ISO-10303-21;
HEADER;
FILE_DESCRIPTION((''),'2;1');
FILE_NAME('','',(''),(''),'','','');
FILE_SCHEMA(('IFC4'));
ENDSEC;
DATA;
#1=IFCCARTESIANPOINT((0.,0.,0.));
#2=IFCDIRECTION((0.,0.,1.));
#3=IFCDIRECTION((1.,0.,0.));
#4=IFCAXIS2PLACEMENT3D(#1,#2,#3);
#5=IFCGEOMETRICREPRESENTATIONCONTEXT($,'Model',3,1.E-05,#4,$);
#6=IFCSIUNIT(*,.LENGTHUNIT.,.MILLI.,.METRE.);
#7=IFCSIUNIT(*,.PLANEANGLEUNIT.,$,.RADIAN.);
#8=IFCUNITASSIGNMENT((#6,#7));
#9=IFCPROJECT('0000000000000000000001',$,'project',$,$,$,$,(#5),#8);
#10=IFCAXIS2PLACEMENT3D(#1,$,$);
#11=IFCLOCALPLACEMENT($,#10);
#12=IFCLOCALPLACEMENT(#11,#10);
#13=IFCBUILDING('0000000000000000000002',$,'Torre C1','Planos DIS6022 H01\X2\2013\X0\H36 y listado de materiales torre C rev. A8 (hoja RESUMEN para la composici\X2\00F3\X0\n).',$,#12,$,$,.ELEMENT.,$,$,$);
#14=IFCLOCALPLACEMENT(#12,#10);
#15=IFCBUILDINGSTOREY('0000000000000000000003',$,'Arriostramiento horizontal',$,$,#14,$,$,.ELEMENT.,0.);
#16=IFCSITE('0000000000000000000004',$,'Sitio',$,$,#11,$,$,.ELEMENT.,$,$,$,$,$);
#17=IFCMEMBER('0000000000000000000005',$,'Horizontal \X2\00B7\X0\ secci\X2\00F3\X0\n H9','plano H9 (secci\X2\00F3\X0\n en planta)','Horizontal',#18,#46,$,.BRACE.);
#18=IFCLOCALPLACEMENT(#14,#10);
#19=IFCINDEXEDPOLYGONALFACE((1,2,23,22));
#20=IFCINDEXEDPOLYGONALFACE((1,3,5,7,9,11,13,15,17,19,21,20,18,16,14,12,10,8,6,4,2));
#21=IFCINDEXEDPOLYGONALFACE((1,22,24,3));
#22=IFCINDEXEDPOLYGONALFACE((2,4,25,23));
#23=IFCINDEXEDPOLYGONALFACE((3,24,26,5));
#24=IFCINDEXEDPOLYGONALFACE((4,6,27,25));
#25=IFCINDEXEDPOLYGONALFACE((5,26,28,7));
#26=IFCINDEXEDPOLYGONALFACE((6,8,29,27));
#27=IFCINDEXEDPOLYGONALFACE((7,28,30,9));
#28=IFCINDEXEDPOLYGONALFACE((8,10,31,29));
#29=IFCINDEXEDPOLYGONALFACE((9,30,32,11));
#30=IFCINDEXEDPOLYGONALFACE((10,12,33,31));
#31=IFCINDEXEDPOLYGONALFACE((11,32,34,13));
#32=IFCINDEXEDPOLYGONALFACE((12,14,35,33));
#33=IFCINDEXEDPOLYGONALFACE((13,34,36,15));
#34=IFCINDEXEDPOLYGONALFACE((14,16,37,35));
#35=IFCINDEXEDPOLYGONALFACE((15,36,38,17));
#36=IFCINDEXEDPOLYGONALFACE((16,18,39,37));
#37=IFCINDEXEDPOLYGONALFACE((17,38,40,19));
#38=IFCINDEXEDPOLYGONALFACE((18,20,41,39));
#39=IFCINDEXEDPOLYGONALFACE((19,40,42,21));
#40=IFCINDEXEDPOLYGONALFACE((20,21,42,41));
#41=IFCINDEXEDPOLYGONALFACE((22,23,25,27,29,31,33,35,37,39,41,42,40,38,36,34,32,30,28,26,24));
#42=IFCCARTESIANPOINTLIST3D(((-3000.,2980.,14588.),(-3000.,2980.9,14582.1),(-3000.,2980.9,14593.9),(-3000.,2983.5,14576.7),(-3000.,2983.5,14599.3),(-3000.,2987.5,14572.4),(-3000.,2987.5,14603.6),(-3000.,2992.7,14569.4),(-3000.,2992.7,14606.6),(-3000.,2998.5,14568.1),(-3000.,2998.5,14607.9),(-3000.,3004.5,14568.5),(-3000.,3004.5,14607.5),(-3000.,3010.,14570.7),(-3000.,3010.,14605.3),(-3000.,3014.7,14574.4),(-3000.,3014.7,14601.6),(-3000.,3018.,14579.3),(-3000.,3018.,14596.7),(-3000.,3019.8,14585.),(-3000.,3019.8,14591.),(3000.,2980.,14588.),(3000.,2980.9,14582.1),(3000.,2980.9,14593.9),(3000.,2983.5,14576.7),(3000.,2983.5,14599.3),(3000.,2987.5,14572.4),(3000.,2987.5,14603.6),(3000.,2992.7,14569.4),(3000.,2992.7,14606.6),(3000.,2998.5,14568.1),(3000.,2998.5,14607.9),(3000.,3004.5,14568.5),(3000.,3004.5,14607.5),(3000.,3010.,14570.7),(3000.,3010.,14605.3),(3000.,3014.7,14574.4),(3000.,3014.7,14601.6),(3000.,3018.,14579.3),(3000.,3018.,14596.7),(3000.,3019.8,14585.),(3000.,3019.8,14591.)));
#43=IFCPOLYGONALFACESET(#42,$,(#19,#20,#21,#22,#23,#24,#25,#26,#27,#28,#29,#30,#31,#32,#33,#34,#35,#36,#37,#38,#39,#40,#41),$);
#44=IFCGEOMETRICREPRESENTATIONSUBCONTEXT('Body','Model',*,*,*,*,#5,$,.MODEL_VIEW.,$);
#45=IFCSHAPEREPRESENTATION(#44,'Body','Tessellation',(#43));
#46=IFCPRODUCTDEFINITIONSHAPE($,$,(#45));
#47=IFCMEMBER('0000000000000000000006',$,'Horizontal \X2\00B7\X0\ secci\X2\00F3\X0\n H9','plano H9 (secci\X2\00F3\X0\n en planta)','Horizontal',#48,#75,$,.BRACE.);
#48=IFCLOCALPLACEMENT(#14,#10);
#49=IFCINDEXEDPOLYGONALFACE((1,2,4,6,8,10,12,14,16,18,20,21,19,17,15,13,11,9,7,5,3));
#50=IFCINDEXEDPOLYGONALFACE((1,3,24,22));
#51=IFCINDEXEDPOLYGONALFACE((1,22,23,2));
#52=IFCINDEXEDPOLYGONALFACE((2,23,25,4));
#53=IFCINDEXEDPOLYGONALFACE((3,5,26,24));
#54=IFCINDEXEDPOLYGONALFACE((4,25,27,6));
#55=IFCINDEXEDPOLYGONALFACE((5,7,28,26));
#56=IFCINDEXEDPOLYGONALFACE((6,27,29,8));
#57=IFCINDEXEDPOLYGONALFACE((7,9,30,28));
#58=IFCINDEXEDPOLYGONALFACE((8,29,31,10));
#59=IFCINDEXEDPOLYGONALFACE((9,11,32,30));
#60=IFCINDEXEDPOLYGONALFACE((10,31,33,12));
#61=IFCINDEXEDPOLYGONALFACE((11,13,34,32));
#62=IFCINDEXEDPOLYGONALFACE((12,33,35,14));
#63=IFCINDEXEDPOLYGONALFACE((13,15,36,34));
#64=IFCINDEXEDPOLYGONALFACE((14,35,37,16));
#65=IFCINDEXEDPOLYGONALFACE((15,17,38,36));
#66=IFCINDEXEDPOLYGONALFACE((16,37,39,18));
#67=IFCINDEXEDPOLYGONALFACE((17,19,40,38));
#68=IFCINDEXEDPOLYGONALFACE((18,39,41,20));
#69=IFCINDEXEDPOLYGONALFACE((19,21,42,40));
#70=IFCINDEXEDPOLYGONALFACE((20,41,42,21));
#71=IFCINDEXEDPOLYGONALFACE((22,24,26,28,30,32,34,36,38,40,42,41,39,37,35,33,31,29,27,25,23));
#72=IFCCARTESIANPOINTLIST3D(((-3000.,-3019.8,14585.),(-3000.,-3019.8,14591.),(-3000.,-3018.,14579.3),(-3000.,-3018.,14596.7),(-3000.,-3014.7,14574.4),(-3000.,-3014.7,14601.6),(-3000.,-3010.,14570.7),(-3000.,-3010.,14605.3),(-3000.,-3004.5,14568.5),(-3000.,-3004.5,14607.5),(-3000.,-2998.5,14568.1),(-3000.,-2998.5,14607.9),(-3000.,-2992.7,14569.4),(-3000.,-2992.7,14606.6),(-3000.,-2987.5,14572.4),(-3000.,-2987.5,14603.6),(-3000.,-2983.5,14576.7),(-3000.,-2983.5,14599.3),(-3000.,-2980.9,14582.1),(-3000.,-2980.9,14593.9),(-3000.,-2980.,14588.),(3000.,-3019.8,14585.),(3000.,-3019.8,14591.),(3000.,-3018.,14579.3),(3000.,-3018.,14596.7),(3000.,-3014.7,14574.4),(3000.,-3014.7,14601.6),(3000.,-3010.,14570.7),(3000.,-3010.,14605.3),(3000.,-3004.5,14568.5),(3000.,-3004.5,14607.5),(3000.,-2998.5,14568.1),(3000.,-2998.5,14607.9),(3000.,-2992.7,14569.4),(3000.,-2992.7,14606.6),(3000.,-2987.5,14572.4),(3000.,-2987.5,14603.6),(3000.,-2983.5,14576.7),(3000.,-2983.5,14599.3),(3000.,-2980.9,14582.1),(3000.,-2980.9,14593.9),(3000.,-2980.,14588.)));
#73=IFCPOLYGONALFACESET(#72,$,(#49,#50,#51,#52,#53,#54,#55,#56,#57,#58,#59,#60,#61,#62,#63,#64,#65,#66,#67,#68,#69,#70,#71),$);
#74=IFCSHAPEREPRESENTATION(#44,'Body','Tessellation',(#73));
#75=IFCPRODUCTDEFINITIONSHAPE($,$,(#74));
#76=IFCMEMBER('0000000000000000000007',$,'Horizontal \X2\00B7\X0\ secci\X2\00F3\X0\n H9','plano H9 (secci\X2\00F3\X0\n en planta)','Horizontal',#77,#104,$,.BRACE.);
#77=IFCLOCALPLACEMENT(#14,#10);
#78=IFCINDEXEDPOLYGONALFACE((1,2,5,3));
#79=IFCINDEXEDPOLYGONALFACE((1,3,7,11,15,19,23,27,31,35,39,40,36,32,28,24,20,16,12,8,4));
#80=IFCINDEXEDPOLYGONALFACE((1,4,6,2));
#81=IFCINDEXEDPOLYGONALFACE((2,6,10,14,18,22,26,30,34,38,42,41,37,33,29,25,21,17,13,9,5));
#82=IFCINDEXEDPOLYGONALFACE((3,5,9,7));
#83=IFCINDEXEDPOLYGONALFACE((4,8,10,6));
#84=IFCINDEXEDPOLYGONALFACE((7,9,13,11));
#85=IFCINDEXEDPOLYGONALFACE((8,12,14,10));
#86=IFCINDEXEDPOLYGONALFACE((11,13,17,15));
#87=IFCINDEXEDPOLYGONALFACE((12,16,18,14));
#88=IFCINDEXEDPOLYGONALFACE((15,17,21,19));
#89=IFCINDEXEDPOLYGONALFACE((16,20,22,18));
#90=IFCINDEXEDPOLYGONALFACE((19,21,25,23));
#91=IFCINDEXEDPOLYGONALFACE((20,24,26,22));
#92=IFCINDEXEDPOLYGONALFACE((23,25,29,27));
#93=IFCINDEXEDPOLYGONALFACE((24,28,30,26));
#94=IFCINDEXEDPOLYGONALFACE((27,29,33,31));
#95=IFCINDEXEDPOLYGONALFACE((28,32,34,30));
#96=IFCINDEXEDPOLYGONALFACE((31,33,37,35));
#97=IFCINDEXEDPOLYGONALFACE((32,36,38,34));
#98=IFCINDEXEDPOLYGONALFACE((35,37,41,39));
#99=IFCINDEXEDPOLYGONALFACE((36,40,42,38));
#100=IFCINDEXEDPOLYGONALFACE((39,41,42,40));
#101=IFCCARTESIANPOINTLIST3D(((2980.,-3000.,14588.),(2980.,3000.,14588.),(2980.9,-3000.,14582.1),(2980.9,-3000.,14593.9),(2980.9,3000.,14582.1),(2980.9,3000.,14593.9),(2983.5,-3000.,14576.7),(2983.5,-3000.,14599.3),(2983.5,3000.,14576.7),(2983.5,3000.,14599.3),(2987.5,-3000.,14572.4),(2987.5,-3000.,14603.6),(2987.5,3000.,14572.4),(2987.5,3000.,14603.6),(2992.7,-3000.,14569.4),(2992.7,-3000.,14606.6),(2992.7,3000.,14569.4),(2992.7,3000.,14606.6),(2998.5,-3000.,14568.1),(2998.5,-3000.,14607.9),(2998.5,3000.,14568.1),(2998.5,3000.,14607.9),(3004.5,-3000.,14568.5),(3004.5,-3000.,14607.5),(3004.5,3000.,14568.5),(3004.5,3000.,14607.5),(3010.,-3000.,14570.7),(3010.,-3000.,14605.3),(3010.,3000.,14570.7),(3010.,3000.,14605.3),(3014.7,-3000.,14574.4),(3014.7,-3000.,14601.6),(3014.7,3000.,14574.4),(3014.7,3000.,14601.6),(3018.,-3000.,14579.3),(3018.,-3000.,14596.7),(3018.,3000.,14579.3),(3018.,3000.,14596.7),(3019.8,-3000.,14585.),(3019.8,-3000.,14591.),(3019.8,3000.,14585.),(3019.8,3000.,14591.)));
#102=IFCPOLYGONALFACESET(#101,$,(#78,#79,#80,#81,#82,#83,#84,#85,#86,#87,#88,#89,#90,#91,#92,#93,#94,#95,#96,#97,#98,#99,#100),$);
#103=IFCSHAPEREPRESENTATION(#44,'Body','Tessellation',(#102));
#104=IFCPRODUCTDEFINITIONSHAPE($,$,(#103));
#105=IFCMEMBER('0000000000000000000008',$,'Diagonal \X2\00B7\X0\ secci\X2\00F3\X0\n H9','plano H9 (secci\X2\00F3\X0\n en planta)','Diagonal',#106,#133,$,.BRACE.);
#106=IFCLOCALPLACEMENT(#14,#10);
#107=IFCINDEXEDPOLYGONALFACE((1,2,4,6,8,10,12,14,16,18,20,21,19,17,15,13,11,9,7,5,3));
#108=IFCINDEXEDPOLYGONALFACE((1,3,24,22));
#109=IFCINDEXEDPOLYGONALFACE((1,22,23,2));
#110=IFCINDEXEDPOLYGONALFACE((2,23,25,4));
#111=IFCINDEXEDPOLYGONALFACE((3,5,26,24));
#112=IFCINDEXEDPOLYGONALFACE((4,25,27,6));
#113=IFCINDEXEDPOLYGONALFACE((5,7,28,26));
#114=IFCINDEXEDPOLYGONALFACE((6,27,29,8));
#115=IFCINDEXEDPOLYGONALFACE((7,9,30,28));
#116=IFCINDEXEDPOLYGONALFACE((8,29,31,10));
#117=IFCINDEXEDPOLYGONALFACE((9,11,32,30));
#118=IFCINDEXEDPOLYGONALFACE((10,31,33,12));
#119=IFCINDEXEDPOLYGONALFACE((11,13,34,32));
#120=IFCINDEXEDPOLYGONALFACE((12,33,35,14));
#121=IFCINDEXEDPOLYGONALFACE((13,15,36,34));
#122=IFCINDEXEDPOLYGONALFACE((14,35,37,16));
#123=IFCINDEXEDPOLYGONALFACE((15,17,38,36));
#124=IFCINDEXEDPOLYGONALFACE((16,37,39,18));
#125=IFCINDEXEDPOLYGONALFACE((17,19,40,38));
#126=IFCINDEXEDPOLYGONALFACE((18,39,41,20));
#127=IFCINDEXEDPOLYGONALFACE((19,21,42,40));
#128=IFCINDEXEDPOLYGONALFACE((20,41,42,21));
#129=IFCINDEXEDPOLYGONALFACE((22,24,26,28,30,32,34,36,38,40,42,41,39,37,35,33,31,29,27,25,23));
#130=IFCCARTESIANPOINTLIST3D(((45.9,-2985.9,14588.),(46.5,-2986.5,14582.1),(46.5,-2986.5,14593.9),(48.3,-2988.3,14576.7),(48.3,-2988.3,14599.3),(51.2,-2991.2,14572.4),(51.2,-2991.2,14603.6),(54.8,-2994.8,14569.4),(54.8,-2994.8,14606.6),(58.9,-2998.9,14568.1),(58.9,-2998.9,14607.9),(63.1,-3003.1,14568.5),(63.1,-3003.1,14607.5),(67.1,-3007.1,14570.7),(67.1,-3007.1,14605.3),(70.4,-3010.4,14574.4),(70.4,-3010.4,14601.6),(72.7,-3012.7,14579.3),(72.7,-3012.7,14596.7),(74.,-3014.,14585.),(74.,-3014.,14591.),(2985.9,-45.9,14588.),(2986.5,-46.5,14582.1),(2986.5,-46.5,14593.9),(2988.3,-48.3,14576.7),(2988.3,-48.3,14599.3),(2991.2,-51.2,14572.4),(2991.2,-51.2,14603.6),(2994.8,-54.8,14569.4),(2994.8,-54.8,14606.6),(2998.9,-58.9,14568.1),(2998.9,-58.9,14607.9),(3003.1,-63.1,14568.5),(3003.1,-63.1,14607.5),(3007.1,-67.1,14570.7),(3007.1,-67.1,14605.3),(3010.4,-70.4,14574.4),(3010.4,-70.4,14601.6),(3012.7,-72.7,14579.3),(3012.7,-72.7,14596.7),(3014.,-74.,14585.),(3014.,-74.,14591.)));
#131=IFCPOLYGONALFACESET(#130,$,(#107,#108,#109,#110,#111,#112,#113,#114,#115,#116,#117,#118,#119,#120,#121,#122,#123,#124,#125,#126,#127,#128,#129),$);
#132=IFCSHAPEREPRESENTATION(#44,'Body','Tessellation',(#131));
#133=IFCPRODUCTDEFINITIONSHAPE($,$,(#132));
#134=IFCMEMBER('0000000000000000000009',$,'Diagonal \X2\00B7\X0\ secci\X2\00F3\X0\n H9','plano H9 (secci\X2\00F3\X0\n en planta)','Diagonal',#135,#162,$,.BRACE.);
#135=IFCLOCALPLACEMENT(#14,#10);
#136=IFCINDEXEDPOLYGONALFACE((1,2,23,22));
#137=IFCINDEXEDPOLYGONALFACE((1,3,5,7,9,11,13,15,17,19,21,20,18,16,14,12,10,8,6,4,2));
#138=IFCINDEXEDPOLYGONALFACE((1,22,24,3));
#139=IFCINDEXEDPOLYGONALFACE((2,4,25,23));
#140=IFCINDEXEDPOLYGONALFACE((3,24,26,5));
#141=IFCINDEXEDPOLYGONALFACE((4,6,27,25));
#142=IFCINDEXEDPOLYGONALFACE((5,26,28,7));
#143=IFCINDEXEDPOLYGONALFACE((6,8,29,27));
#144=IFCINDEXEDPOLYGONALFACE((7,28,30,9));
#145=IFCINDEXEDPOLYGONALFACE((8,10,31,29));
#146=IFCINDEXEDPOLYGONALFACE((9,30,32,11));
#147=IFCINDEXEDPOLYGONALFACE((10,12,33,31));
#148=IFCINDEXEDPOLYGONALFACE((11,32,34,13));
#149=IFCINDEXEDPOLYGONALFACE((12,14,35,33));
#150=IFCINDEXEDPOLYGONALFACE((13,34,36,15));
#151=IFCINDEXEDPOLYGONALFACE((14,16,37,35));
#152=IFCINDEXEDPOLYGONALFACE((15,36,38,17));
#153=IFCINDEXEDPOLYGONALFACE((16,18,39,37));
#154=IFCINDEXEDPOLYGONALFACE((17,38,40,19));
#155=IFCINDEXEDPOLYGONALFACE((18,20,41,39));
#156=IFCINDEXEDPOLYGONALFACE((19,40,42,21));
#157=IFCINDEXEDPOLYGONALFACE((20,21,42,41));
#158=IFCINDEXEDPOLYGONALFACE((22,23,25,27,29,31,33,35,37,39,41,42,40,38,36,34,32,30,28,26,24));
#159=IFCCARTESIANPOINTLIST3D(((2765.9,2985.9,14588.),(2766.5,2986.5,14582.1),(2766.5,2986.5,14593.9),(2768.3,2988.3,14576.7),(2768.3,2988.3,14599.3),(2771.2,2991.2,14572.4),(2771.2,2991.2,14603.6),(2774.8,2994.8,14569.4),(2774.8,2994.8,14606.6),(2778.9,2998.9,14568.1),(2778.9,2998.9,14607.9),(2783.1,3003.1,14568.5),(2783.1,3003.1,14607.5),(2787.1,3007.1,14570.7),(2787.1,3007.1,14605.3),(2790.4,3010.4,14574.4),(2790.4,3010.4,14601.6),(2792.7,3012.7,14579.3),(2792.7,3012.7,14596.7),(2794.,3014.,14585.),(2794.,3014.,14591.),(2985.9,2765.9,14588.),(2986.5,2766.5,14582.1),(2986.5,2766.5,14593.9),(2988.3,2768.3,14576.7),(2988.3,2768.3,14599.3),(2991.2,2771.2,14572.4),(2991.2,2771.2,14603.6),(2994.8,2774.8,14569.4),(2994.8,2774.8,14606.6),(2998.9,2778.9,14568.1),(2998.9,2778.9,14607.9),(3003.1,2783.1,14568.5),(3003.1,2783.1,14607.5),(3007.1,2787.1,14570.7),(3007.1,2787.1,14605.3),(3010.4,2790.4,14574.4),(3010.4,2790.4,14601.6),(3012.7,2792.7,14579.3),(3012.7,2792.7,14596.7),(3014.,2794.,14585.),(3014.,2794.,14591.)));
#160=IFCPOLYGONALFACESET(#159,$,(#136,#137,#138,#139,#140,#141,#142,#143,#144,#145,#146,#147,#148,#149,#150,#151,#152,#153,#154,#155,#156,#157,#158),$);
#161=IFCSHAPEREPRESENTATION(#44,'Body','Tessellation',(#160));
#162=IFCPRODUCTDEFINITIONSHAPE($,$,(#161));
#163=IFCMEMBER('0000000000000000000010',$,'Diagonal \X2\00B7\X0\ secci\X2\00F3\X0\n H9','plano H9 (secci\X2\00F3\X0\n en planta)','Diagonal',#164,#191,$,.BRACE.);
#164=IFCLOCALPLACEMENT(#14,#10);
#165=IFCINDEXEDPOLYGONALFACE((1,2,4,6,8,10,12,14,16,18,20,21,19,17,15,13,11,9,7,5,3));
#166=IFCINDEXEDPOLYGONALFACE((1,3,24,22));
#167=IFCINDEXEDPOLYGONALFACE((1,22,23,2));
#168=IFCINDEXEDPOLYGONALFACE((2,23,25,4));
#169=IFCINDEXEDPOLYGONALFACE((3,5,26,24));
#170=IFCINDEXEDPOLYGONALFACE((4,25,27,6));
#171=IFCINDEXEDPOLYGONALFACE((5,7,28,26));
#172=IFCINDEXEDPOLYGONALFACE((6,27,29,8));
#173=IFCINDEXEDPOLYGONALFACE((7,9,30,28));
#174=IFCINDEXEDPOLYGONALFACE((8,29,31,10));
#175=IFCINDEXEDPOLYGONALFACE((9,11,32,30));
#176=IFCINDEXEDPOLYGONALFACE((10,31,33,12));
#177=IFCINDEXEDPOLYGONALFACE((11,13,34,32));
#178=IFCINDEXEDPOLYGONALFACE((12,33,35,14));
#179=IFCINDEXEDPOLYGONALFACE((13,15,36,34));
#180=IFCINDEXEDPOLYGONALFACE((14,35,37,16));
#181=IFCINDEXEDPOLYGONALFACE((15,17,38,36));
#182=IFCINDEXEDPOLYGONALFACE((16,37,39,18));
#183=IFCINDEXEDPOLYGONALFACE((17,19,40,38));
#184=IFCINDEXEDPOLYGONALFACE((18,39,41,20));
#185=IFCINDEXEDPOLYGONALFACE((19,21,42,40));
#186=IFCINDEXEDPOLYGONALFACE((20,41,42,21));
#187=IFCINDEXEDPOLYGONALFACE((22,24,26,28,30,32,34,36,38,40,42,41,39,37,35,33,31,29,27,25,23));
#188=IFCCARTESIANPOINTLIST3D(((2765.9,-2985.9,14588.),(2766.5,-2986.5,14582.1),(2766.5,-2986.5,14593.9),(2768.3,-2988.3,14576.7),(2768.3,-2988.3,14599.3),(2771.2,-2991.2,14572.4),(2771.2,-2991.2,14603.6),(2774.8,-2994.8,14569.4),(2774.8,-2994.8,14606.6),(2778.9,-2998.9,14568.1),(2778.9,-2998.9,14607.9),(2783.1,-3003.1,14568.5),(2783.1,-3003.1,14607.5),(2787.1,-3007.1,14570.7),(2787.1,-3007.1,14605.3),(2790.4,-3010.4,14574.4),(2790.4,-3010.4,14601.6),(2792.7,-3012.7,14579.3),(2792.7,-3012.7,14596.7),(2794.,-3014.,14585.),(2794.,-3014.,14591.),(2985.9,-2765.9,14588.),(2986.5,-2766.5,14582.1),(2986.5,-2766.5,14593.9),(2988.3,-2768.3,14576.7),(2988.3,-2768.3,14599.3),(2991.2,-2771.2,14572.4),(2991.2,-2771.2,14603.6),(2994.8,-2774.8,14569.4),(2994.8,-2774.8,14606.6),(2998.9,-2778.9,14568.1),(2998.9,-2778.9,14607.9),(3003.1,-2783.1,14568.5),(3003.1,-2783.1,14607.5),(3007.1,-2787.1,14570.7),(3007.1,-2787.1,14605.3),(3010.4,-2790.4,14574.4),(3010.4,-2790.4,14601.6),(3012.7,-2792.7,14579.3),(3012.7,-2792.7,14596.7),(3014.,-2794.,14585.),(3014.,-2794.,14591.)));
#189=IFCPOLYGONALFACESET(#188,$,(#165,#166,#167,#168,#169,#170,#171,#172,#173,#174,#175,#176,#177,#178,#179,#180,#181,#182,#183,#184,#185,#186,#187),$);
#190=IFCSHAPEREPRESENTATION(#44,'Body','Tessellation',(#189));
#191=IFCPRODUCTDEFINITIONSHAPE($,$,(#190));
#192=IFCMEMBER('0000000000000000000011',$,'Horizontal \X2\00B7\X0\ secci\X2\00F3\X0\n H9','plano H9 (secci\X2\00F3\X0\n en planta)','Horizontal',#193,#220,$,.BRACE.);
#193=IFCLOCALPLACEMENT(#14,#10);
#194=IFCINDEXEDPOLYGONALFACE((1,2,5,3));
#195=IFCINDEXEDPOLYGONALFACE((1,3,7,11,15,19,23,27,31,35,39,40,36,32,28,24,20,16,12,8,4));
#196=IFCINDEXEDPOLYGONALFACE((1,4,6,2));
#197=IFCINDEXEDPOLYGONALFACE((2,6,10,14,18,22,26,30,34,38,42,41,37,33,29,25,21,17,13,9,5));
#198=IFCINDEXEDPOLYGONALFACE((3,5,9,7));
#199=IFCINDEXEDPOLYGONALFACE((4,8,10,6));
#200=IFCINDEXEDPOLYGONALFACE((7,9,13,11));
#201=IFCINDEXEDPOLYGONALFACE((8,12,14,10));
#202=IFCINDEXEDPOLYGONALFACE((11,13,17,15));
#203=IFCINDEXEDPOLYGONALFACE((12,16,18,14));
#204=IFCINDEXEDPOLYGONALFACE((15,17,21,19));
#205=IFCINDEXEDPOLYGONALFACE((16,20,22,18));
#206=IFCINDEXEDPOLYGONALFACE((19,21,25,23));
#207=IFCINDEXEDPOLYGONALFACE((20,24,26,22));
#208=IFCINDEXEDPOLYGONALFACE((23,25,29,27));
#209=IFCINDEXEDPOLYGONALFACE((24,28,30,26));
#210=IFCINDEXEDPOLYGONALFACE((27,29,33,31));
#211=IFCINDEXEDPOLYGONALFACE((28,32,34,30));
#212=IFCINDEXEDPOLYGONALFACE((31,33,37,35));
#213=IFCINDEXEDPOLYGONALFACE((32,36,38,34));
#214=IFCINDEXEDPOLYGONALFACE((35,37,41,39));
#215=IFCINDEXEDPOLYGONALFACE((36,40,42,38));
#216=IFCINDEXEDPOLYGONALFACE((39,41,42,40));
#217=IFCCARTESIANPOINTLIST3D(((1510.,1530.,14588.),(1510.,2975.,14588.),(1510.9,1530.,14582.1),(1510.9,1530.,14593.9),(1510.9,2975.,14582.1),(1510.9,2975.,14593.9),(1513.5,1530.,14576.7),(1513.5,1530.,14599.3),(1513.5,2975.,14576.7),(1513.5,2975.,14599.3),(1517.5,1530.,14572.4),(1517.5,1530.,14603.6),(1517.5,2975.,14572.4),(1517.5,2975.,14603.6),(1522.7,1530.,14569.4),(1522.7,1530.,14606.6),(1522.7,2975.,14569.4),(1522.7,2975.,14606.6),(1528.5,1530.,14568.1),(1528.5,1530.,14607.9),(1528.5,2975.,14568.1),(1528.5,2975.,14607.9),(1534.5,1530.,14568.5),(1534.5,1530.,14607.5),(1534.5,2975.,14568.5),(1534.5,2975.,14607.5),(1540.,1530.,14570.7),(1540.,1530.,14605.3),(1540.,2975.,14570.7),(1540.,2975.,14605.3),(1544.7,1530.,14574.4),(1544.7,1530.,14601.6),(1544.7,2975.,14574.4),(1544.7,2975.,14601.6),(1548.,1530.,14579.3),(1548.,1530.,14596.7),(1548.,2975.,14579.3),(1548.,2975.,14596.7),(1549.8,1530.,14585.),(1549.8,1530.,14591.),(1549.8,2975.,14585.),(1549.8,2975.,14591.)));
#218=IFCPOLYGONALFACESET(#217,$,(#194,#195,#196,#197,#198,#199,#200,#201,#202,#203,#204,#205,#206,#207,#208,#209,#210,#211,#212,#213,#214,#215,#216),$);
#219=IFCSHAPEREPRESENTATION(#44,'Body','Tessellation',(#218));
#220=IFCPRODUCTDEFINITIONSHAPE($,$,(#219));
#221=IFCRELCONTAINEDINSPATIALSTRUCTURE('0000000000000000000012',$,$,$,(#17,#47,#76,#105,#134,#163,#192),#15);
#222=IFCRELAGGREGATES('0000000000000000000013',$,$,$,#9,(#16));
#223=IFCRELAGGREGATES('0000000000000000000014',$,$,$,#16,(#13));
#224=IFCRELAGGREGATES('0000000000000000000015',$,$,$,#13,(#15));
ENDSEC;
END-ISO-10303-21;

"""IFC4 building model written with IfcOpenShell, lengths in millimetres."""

from ifc_helpers import new_model, si_unit, frame, origin, origin_with_axes, place, context, subcontext, project, spatial, circle, extrude, element, save


model = new_model("IFC4")

# Units and contexts
model_context = context("Model", 3, precision=1e-05, world=origin_with_axes())
body_context = subcontext(model_context, "Body", "Model", "MODEL_VIEW")
ifc_project = project(units=[si_unit("LENGTHUNIT", "METRE", prefix="MILLI"), si_unit("PLANEANGLEUNIT", "RADIAN")], contexts=[model_context])

# Site, building, storey
site_placement = place(None, origin())
site = spatial("IfcSite", under=ifc_project, at=site_placement, Name="Sitio", CompositionType="ELEMENT")
building_placement = place(site_placement, origin())
building = spatial("IfcBuilding", under=site, at=building_placement, Name="Torre C1", Description="Planos DIS6022 H01–H36 y listado de materiales torre C rev. A8 (hoja RESUMEN para la composición).", CompositionType="ELEMENT")
storey_placement = place(building_placement, origin())
storey = spatial("IfcBuildingStorey", under=building, at=storey_placement, Name="Arriostramiento horizontal", CompositionType="ELEMENT", Elevation=0.0)

# Members
for number, where, z_axis, x_axis, name in (
    (1, (3000.0, 3000.0, 14588.0), (-1.0, 0.0, 0.0), (0.0, -1.0, 0.0), "Horizontal · sección H9"),
    (2, (3000.0, -3000.0, 14588.0), (-1.0, 0.0, 0.0), (0.0, 1.0, 0.0), "Horizontal · sección H9"),
    (3, (3000.0, 3000.0, 14588.0), (0.0, -1.0, 0.0), (-1.0, 0.0, 0.0), "Horizontal · sección H9"),
):
    element("IfcMember", number, at=place(storey_placement, frame(where, z_axis=z_axis, x_axis=x_axis)), inside=storey, Name=name, Description="plano H9 (sección en planta)", ObjectType="Horizontal", PredefinedType="BRACE", context=body_context, shape_type="SweptSolid", body=[
        extrude(circle(Radius=20.0), None, (0.0, 0.0, 1.0), 6000.0),
    ])
member_1_placement = place(storey_placement, frame((3000.0, -60.0, 14588.0), z_axis=(-0.707107, -0.707107, 0.0), x_axis=(-0.707107, 0.707107, 0.0)))
element("IfcMember", 4, at=member_1_placement, inside=storey, Name="Diagonal · sección H9", Description="plano H9 (sección en planta)", ObjectType="Diagonal", PredefinedType="BRACE", context=body_context, shape_type="SweptSolid", body=[
    extrude(circle(Radius=20.0), None, (0.0, 0.0, 1.0), 4157.8),
])
for number, where, z_axis, x_axis, name in (
    (5, (3000.0, 2780.0, 14588.0), (-0.707107, 0.707107, 0.0), (-0.707107, -0.707107, 0.0), "Diagonal · sección H9"),
    (6, (2780.0, -3000.0, 14588.0), (0.707107, 0.707107, 0.0), (-0.707107, 0.707107, 0.0), "Diagonal · sección H9"),
):
    element("IfcMember", number, at=place(storey_placement, frame(where, z_axis=z_axis, x_axis=x_axis)), inside=storey, Name=name, Description="plano H9 (sección en planta)", ObjectType="Diagonal", PredefinedType="BRACE", context=body_context, shape_type="SweptSolid", body=[
        extrude(circle(Radius=20.0), None, (0.0, 0.0, 1.0), 311.1),
    ])
member_2_placement = place(storey_placement, frame((1530.0, 1530.0, 14588.0), z_axis=(0.0, 1.0, 0.0), x_axis=(-1.0, 0.0, 0.0)))
element("IfcMember", 7, at=member_2_placement, inside=storey, Name="Horizontal · sección H9", Description="plano H9 (sección en planta)", ObjectType="Horizontal", PredefinedType="BRACE", context=body_context, shape_type="SweptSolid", body=[
    extrude(circle(Radius=20.0), None, (0.0, 0.0, 1.0), 1445.0),
])

save(model, "model.ifc")
